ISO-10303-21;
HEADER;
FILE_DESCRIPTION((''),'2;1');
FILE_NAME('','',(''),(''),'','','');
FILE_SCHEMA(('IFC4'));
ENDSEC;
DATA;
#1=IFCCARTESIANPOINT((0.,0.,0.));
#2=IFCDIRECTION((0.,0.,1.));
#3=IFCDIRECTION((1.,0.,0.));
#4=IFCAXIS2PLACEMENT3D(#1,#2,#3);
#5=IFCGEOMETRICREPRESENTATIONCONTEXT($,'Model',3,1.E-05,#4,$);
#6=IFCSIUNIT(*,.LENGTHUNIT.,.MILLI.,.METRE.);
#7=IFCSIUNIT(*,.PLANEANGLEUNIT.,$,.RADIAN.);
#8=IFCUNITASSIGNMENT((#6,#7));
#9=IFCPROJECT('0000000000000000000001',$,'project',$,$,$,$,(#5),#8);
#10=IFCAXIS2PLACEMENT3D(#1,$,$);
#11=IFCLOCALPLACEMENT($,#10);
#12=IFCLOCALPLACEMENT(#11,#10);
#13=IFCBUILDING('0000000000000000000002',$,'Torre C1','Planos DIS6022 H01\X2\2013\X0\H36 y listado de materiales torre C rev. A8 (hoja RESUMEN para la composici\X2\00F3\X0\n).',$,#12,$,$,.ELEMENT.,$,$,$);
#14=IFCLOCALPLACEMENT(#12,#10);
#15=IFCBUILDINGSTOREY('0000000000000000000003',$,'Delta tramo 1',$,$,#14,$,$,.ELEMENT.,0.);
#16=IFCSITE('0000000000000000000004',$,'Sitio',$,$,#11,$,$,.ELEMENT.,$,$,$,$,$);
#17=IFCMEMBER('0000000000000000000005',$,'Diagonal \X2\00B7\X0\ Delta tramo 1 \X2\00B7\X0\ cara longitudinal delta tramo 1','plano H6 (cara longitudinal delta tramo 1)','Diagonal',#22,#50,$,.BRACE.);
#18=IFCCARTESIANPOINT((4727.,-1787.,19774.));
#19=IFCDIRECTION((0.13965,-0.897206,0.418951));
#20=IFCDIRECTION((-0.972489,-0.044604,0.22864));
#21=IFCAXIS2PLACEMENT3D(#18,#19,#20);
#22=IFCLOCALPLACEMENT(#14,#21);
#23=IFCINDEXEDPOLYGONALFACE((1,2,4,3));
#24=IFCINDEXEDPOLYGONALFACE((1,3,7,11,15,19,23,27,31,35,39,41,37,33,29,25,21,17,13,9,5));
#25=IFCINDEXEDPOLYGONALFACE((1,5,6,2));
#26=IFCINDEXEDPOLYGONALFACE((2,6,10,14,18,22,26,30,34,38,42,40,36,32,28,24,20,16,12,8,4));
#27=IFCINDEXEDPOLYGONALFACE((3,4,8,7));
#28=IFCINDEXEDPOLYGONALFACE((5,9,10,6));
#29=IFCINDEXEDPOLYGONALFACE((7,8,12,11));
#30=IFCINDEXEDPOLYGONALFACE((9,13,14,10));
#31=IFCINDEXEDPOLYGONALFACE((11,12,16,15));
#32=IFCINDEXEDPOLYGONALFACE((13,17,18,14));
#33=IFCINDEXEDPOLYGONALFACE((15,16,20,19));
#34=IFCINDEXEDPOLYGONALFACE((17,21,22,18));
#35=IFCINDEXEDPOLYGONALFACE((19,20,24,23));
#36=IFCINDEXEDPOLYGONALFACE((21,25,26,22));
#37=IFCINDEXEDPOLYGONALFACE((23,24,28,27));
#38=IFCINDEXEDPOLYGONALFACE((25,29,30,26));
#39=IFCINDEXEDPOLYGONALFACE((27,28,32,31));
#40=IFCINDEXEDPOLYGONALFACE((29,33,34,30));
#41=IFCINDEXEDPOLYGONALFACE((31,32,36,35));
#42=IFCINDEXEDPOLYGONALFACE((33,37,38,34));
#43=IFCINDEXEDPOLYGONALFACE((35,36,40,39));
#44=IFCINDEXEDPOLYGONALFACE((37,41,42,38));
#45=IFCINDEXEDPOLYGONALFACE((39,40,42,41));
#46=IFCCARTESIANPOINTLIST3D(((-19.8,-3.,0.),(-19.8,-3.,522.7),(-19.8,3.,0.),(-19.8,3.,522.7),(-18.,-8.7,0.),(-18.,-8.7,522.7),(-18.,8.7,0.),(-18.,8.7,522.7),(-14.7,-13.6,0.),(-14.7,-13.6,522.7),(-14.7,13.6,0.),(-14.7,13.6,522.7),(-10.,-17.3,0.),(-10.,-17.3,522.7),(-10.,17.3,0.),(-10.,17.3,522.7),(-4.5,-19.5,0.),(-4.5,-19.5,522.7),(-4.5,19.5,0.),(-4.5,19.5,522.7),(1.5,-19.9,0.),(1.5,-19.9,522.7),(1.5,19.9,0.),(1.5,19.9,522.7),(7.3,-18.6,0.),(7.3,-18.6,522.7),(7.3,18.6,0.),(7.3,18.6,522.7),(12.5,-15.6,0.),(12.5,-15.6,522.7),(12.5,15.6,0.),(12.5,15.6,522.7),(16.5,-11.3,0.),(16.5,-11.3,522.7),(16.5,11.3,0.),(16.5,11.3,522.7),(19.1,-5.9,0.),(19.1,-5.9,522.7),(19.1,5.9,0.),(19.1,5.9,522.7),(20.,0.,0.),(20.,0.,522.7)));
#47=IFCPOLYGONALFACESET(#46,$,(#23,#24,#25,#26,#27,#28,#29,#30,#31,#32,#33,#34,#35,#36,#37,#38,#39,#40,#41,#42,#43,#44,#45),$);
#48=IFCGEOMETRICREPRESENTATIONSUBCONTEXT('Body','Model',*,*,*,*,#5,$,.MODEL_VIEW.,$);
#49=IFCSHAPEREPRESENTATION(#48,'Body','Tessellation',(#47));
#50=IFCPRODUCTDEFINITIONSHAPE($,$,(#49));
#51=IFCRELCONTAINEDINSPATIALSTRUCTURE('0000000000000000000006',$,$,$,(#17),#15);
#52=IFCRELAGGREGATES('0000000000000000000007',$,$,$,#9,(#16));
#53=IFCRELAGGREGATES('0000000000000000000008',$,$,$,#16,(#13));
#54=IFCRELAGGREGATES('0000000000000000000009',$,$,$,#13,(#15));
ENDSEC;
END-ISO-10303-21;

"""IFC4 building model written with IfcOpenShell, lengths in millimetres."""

from ifc_helpers import new_model, si_unit, frame, origin, origin_with_axes, place, context, subcontext, project, spatial, circle, extrude, element, save


model = new_model("IFC4")

# Units and contexts
model_context = context("Model", 3, precision=1e-05, world=origin_with_axes())
body_context = subcontext(model_context, "Body", "Model", "MODEL_VIEW")
ifc_project = project(units=[si_unit("LENGTHUNIT", "METRE", prefix="MILLI"), si_unit("PLANEANGLEUNIT", "RADIAN")], contexts=[model_context])

# Site, building, storey
site_placement = place(None, origin())
site = spatial("IfcSite", under=ifc_project, at=site_placement, Name="Sitio", CompositionType="ELEMENT")
building_placement = place(site_placement, origin())
building = spatial("IfcBuilding", under=site, at=building_placement, Name="Torre C1", Description="Planos DIS6022 H01–H36 y listado de materiales torre C rev. A8 (hoja RESUMEN para la composición).", CompositionType="ELEMENT")
storey_placement = place(building_placement, origin())
storey = spatial("IfcBuildingStorey", under=building, at=storey_placement, Name="Delta tramo 1", CompositionType="ELEMENT", Elevation=0.0)

# Member
member_1_placement = place(storey_placement, frame((4727.0, -1787.0, 19774.0), z_axis=(0.13965, -0.897206, 0.418951), x_axis=(-0.972489, -0.044604, 0.22864)))
element("IfcMember", 1, at=member_1_placement, inside=storey, Name="Diagonal · Delta tramo 1 · cara longitudinal delta tramo 1", Description="plano H6 (cara longitudinal delta tramo 1)", ObjectType="Diagonal", PredefinedType="BRACE", context=body_context, shape_type="SweptSolid", body=[
    extrude(circle(Radius=20.0), None, (0.0, 0.0, 1.0), 522.7),
])

save(model, "model.ifc")
